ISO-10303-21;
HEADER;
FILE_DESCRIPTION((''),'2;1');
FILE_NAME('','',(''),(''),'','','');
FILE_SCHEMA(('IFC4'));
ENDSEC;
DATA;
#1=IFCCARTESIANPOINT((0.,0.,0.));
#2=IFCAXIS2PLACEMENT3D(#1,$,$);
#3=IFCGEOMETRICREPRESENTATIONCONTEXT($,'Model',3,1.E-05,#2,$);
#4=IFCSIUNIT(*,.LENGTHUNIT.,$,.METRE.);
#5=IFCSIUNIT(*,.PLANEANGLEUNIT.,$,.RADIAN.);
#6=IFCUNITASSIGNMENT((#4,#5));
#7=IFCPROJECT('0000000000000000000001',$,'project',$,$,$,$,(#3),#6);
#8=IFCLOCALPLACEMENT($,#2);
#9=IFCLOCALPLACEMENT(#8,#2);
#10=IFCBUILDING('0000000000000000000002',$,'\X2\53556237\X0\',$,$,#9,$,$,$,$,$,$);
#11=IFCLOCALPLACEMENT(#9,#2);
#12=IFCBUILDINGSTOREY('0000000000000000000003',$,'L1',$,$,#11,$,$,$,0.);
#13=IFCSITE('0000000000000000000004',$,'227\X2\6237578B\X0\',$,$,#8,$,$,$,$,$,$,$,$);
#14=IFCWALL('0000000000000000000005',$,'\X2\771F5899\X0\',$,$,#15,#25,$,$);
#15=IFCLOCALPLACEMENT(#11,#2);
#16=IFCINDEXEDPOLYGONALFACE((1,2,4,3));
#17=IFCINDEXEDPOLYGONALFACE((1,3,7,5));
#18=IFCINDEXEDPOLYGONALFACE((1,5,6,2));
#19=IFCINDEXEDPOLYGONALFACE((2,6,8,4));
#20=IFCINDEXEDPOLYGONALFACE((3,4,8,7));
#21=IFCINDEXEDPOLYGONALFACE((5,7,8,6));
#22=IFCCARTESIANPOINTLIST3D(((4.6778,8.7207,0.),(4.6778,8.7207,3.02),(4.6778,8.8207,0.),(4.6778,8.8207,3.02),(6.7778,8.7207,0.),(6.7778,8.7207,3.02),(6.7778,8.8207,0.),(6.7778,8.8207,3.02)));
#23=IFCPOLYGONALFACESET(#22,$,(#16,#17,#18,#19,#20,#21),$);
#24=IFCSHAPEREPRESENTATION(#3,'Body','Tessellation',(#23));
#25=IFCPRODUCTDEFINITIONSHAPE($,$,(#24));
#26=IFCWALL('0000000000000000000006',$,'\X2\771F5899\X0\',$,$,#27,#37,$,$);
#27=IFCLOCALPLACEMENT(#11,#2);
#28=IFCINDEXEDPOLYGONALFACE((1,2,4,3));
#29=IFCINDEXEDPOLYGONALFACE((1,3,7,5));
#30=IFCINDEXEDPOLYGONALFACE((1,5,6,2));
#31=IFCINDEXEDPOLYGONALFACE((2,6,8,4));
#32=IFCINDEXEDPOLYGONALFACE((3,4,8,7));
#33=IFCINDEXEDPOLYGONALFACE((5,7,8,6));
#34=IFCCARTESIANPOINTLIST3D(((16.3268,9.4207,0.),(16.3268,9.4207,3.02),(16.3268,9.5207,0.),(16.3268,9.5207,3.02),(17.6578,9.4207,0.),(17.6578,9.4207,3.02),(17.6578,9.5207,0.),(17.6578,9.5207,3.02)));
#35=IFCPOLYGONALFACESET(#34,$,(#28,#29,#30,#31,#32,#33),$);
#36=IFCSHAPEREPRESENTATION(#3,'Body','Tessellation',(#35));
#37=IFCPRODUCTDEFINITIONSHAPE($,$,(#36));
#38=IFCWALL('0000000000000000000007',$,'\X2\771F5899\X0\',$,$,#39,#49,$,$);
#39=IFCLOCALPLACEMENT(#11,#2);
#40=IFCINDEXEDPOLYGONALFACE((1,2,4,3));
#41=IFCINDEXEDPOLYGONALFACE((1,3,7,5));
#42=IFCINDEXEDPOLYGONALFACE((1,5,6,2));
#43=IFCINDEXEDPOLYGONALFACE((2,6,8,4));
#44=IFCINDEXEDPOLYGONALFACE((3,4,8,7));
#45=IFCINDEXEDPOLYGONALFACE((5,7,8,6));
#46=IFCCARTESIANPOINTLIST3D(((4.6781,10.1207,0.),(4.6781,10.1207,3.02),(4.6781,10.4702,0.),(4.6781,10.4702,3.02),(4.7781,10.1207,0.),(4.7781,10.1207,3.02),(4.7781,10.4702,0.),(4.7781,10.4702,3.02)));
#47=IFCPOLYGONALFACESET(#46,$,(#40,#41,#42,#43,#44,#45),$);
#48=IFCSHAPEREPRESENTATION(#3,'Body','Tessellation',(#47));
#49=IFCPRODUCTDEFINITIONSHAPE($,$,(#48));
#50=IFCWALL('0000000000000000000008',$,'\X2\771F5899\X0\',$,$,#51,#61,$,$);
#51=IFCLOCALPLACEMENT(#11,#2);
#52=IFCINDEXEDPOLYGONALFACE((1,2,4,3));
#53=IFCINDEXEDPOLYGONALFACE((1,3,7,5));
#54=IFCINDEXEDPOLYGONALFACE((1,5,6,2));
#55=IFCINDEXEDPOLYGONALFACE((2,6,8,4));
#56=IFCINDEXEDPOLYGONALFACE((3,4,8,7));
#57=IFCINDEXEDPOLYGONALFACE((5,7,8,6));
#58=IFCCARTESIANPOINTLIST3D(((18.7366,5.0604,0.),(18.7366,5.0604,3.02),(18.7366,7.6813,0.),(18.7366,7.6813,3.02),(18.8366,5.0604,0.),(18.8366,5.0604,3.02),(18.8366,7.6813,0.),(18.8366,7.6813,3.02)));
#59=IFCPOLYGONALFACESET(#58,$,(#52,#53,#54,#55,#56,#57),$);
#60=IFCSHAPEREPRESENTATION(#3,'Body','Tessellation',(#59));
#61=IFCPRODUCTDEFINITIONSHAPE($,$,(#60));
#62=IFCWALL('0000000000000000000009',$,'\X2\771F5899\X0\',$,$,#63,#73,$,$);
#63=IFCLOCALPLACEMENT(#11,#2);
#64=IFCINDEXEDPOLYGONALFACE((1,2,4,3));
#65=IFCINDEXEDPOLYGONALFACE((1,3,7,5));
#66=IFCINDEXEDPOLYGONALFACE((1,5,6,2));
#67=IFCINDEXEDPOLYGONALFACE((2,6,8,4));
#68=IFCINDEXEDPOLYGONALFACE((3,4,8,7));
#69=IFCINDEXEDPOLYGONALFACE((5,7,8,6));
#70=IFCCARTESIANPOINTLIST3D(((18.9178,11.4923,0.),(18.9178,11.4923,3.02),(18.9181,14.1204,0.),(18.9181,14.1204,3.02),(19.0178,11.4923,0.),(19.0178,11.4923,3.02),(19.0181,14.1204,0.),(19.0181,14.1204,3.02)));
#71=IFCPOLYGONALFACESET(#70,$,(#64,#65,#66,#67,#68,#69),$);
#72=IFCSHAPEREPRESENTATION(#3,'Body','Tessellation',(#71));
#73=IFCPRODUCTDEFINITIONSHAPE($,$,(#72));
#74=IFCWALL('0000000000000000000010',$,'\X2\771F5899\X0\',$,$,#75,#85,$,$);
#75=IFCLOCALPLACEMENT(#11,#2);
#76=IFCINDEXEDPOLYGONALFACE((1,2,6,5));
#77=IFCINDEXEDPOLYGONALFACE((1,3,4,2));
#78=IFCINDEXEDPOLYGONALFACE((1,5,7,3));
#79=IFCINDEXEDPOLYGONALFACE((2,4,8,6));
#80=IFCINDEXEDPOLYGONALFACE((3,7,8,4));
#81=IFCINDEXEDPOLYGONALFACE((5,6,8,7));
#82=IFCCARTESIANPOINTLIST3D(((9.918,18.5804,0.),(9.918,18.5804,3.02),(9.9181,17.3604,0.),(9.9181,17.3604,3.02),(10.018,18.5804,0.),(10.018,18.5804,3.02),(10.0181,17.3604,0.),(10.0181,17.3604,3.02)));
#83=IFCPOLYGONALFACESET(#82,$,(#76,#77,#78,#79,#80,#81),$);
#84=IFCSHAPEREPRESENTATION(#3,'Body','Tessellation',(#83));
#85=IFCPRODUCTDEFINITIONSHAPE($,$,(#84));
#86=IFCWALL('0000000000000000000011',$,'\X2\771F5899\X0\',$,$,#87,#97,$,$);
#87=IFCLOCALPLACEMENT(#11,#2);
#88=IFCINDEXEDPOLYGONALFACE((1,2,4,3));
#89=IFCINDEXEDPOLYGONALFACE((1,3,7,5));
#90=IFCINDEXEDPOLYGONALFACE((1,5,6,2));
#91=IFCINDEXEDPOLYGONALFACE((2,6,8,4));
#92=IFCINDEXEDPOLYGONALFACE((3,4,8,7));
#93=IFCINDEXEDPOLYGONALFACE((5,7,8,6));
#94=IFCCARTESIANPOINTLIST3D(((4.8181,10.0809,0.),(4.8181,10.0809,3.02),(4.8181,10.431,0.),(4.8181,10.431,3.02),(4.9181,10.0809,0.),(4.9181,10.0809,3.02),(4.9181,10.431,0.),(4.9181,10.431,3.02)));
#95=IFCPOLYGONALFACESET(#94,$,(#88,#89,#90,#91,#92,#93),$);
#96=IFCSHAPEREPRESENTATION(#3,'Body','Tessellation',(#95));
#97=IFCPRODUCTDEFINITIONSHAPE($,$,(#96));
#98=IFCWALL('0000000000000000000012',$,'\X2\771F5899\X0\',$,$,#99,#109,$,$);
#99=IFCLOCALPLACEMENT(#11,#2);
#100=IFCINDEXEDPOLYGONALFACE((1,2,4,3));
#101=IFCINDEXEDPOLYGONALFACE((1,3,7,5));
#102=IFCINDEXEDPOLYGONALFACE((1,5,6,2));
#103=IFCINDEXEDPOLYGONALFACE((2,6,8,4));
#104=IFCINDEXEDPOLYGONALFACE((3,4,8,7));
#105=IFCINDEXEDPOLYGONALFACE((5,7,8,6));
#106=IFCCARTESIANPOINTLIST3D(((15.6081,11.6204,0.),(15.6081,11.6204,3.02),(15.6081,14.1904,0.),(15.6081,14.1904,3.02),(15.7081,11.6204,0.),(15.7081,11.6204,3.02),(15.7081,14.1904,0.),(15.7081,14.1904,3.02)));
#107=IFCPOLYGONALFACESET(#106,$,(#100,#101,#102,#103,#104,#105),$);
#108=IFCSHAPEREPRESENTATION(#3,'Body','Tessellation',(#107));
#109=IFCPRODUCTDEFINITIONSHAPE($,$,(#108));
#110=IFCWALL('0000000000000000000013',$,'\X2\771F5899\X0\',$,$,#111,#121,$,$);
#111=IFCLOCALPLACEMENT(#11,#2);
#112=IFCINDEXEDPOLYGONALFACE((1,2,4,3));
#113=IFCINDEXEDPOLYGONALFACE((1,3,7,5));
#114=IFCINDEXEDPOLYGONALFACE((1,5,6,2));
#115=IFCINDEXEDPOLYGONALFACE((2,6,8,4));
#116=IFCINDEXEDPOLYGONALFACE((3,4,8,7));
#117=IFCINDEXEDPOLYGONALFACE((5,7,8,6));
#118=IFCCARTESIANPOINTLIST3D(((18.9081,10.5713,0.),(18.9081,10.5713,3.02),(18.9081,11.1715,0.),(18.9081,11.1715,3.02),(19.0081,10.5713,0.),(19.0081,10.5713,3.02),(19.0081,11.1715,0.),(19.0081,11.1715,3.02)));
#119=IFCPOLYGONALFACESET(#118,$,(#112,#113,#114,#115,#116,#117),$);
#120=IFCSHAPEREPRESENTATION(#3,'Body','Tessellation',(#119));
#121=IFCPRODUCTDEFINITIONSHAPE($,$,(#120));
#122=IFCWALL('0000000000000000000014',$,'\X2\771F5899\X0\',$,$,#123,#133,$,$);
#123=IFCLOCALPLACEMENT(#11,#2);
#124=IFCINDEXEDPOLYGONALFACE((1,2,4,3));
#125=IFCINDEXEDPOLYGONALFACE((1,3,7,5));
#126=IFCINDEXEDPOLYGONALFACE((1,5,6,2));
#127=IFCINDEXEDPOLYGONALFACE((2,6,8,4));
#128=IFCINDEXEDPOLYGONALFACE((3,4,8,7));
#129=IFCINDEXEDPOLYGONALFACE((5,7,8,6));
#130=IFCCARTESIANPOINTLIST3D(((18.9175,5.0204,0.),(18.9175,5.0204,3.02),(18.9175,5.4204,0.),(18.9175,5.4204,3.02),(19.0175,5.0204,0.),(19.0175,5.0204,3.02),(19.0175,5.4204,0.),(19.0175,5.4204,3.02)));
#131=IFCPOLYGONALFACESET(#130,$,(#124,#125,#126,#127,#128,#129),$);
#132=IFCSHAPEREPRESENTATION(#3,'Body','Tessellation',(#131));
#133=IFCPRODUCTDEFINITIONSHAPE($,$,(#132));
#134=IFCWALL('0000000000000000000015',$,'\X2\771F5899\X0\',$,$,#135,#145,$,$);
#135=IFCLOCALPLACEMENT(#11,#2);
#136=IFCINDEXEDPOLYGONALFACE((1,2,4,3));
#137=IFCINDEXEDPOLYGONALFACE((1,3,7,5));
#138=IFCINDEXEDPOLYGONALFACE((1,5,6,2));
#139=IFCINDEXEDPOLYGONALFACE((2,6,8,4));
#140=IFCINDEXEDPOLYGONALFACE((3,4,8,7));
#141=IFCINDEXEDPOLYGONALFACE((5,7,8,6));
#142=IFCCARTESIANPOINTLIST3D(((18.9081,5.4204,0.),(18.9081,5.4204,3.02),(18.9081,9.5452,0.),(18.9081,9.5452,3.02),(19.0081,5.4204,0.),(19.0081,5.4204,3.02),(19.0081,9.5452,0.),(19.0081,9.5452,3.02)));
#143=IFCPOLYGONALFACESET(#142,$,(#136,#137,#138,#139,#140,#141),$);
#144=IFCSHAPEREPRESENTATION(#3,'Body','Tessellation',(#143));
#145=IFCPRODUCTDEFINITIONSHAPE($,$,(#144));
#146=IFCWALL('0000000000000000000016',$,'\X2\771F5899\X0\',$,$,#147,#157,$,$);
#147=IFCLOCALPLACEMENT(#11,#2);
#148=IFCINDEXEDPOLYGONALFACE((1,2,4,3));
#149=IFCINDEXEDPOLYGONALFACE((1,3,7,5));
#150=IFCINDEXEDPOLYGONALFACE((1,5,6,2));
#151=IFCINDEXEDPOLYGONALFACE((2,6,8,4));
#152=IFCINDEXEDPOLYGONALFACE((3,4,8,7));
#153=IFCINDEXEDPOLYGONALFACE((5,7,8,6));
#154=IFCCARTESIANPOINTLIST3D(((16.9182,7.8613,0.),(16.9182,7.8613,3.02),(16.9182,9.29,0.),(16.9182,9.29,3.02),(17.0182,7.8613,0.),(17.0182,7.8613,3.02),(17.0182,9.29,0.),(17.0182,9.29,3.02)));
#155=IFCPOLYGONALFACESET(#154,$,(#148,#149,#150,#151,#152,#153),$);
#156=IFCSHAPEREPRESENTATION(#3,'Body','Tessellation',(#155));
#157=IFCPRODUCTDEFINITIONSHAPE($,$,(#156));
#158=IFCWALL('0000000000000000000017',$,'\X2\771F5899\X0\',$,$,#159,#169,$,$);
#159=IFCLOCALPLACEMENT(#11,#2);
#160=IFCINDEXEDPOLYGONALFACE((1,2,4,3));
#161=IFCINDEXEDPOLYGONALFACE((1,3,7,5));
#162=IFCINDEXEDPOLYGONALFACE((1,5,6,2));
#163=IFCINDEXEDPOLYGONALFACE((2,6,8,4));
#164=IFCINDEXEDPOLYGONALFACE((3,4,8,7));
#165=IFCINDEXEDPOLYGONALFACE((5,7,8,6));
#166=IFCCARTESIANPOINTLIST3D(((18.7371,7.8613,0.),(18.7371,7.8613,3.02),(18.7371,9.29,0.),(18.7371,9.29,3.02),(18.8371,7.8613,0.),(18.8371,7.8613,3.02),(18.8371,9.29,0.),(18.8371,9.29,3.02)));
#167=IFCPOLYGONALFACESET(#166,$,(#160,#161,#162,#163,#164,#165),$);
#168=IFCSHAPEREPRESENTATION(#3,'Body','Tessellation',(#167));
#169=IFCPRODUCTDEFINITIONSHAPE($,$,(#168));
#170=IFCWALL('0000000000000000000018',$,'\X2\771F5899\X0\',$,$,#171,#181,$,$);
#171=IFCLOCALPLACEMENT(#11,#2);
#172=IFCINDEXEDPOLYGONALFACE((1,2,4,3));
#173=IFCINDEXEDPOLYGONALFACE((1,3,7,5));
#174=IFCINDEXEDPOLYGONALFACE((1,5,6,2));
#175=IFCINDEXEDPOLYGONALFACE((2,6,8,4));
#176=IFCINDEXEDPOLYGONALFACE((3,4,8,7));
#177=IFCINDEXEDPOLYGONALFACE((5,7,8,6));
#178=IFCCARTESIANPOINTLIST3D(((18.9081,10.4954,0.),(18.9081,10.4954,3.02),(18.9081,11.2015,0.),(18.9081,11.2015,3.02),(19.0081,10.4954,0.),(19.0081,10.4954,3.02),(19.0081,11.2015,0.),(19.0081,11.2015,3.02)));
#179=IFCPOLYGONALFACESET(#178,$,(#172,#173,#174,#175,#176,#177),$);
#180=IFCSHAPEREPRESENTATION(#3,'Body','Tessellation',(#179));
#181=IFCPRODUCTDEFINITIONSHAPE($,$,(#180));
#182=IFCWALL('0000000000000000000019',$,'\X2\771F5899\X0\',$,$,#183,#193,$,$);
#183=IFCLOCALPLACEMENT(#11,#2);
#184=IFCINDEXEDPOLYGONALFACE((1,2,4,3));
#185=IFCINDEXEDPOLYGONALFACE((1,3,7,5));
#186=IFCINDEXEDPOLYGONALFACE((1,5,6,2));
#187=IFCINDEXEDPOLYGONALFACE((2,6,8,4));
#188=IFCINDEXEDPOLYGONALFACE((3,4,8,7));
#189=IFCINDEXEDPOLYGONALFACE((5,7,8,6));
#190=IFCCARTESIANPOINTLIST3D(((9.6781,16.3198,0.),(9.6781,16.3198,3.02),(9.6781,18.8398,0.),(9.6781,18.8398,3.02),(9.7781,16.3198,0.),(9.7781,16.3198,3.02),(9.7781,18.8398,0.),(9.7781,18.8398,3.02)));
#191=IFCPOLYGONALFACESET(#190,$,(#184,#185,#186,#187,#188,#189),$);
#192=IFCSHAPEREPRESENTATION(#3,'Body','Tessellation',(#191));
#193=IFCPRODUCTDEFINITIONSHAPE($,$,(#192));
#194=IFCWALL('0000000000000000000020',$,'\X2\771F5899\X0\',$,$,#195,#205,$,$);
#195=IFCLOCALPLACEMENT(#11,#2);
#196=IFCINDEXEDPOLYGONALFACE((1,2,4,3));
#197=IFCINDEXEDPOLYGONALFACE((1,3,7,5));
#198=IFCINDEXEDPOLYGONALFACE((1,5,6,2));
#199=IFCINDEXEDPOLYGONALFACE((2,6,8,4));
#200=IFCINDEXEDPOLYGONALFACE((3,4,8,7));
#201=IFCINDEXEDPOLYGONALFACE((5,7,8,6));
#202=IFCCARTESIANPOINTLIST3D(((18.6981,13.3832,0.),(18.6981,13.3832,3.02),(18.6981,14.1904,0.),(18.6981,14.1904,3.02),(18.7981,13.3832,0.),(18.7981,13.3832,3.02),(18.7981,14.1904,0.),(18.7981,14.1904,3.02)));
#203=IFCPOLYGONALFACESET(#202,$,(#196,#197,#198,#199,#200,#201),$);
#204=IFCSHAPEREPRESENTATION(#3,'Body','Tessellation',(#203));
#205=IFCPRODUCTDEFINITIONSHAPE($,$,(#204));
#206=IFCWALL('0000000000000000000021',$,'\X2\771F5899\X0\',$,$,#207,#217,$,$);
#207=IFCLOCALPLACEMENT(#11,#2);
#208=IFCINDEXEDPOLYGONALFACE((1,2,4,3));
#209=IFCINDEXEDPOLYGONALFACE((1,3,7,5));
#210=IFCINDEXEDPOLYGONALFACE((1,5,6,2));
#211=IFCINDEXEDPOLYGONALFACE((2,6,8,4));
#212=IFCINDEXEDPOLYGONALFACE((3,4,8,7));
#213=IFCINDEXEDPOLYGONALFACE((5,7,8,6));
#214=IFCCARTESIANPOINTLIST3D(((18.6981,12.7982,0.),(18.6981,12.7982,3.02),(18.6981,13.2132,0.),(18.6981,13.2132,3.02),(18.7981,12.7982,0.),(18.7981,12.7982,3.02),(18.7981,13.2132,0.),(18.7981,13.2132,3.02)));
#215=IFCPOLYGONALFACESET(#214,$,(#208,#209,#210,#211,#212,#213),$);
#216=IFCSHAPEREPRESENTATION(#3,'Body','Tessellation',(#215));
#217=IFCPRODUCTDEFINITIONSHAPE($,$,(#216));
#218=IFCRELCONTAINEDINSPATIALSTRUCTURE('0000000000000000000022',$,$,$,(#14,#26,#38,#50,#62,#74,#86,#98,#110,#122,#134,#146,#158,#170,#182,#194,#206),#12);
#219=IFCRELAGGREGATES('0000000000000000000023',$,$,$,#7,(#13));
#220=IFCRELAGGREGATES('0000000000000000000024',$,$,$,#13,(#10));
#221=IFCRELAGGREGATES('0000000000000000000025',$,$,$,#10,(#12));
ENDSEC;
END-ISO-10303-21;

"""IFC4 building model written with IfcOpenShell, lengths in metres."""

from ifc_helpers import new_model, si_unit, origin, place, context, project, spatial, polyline, outline, extrude, element, save


model = new_model("IFC4")

# Units and contexts
model_context = context("Model", 3, precision=1e-05, world=origin())
ifc_project = project(units=[si_unit("LENGTHUNIT", "METRE"), si_unit("PLANEANGLEUNIT", "RADIAN")], contexts=[model_context])

# Site, building, storey
site_placement = place(None, origin())
site = spatial("IfcSite", under=ifc_project, at=site_placement, Name="227户型")
building_placement = place(site_placement, origin())
building = spatial("IfcBuilding", under=site, at=building_placement, Name="单户")
storey_placement = place(building_placement, origin())
storey = spatial("IfcBuildingStorey", under=building, at=storey_placement, Name="L1", Elevation=0.0)

# Walls
wall_1_placement = place(storey_placement, origin())
element("IfcWall", 1, at=wall_1_placement, inside=storey, Name="真墙", context=model_context, shape_type="SweptSolid", body=[
    extrude(outline(polyline([(6.7778, 8.7207), (4.6778, 8.7207), (4.6778, 8.8207), (6.7778, 8.8207), (6.7778, 8.7207)])), origin(), (0.0, 0.0, 1.0), 3.02),
])
wall_2_placement = place(storey_placement, origin())
element("IfcWall", 2, at=wall_2_placement, inside=storey, Name="真墙", context=model_context, shape_type="SweptSolid", body=[
    extrude(outline(polyline([(16.3268, 9.5207), (17.6578, 9.5207), (17.6578, 9.4207), (16.3268, 9.4207), (16.3268, 9.5207)])), origin(), (0.0, 0.0, 1.0), 3.02),
])
wall_3_placement = place(storey_placement, origin())
element("IfcWall", 3, at=wall_3_placement, inside=storey, Name="真墙", context=model_context, shape_type="SweptSolid", body=[
    extrude(outline(polyline([(4.6781, 10.1207), (4.6781, 10.4702), (4.7781, 10.4702), (4.7781, 10.1207), (4.6781, 10.1207)])), origin(), (0.0, 0.0, 1.0), 3.02),
])
wall_4_placement = place(storey_placement, origin())
element("IfcWall", 4, at=wall_4_placement, inside=storey, Name="真墙", context=model_context, shape_type="SweptSolid", body=[
    extrude(outline(polyline([(18.8366, 7.6813), (18.8366, 5.0604), (18.7366, 5.0604), (18.7366, 7.6813), (18.8366, 7.6813)])), origin(), (0.0, 0.0, 1.0), 3.02),
])
wall_5_placement = place(storey_placement, origin())
element("IfcWall", 5, at=wall_5_placement, inside=storey, Name="真墙", context=model_context, shape_type="SweptSolid", body=[
    extrude(outline(polyline([(18.9178, 11.4923), (18.9181, 14.1204), (19.0181, 14.1204), (19.0178, 11.4923), (18.9178, 11.4923)])), origin(), (0.0, 0.0, 1.0), 3.02),
])
wall_6_placement = place(storey_placement, origin())
element("IfcWall", 6, at=wall_6_placement, inside=storey, Name="真墙", context=model_context, shape_type="SweptSolid", body=[
    extrude(outline(polyline([(10.018, 18.5804), (10.0181, 17.3604), (9.9181, 17.3604), (9.918, 18.5804), (10.018, 18.5804)])), origin(), (0.0, 0.0, 1.0), 3.02),
])
wall_7_placement = place(storey_placement, origin())
element("IfcWall", 7, at=wall_7_placement, inside=storey, Name="真墙", context=model_context, shape_type="SweptSolid", body=[
    extrude(outline(polyline([(4.9181, 10.431), (4.9181, 10.0809), (4.8181, 10.0809), (4.8181, 10.431), (4.9181, 10.431)])), origin(), (0.0, 0.0, 1.0), 3.02),
])

# Wall
wall_8_placement = place(storey_placement, origin())
element("IfcWall", 8, at=wall_8_placement, inside=storey, Name="真墙", context=model_context, shape_type="SweptSolid", body=[
    extrude(outline(polyline([(15.7081, 14.1904), (15.7081, 11.6204), (15.6081, 11.6204), (15.6081, 14.1904), (15.7081, 14.1904)])), origin(), (0.0, 0.0, 1.0), 3.02),
])

# Walls
wall_9_placement = place(storey_placement, origin())
element("IfcWall", 9, at=wall_9_placement, inside=storey, Name="真墙", context=model_context, shape_type="SweptSolid", body=[
    extrude(outline(polyline([(19.0081, 11.1715), (19.0081, 10.5713), (18.9081, 10.5713), (18.9081, 11.1715), (19.0081, 11.1715)])), origin(), (0.0, 0.0, 1.0), 3.02),
])
wall_10_placement = place(storey_placement, origin())
element("IfcWall", 10, at=wall_10_placement, inside=storey, Name="真墙", context=model_context, shape_type="SweptSolid", body=[
    extrude(outline(polyline([(19.0175, 5.4204), (19.0175, 5.0204), (18.9175, 5.0204), (18.9175, 5.4204), (19.0175, 5.4204)])), origin(), (0.0, 0.0, 1.0), 3.02),
])
wall_11_placement = place(storey_placement, origin())
element("IfcWall", 11, at=wall_11_placement, inside=storey, Name="真墙", context=model_context, shape_type="SweptSolid", body=[
    extrude(outline(polyline([(18.9081, 5.4204), (18.9081, 9.5452), (19.0081, 9.5452), (19.0081, 5.4204), (18.9081, 5.4204)])), origin(), (0.0, 0.0, 1.0), 3.02),
])
wall_12_placement = place(storey_placement, origin())
element("IfcWall", 12, at=wall_12_placement, inside=storey, Name="真墙", context=model_context, shape_type="SweptSolid", body=[
    extrude(outline(polyline([(17.0182, 9.29), (17.0182, 7.8613), (16.9182, 7.8613), (16.9182, 9.29), (17.0182, 9.29)])), origin(), (0.0, 0.0, 1.0), 3.02),
])
wall_13_placement = place(storey_placement, origin())
element("IfcWall", 13, at=wall_13_placement, inside=storey, Name="真墙", context=model_context, shape_type="SweptSolid", body=[
    extrude(outline(polyline([(18.7371, 7.8613), (18.7371, 9.29), (18.8371, 9.29), (18.8371, 7.8613), (18.7371, 7.8613)])), origin(), (0.0, 0.0, 1.0), 3.02),
])
wall_14_placement = place(storey_placement, origin())
element("IfcWall", 14, at=wall_14_placement, inside=storey, Name="真墙", context=model_context, shape_type="SweptSolid", body=[
    extrude(outline(polyline([(19.0081, 11.2015), (19.0081, 10.4954), (18.9081, 10.4954), (18.9081, 11.2015), (19.0081, 11.2015)])), origin(), (0.0, 0.0, 1.0), 3.02),
])
wall_15_placement = place(storey_placement, origin())
element("IfcWall", 15, at=wall_15_placement, inside=storey, Name="真墙", context=model_context, shape_type="SweptSolid", body=[
    extrude(outline(polyline([(9.6781, 16.3198), (9.6781, 18.8398), (9.7781, 18.8398), (9.7781, 16.3198), (9.6781, 16.3198)])), origin(), (0.0, 0.0, 1.0), 3.02),
])

# Walls
wall_16_placement = place(storey_placement, origin())
element("IfcWall", 16, at=wall_16_placement, inside=storey, Name="真墙", context=model_context, shape_type="SweptSolid", body=[
    extrude(outline(polyline([(18.6981, 13.3832), (18.6981, 14.1904), (18.7981, 14.1904), (18.7981, 13.3832), (18.6981, 13.3832)])), origin(), (0.0, 0.0, 1.0), 3.02),
])
wall_17_placement = place(storey_placement, origin())
element("IfcWall", 17, at=wall_17_placement, inside=storey, Name="真墙", context=model_context, shape_type="SweptSolid", body=[
    extrude(outline(polyline([(18.7981, 13.2132), (18.7981, 12.7982), (18.6981, 12.7982), (18.6981, 13.2132), (18.7981, 13.2132)])), origin(), (0.0, 0.0, 1.0), 3.02),
])

save(model, "model.ifc")
